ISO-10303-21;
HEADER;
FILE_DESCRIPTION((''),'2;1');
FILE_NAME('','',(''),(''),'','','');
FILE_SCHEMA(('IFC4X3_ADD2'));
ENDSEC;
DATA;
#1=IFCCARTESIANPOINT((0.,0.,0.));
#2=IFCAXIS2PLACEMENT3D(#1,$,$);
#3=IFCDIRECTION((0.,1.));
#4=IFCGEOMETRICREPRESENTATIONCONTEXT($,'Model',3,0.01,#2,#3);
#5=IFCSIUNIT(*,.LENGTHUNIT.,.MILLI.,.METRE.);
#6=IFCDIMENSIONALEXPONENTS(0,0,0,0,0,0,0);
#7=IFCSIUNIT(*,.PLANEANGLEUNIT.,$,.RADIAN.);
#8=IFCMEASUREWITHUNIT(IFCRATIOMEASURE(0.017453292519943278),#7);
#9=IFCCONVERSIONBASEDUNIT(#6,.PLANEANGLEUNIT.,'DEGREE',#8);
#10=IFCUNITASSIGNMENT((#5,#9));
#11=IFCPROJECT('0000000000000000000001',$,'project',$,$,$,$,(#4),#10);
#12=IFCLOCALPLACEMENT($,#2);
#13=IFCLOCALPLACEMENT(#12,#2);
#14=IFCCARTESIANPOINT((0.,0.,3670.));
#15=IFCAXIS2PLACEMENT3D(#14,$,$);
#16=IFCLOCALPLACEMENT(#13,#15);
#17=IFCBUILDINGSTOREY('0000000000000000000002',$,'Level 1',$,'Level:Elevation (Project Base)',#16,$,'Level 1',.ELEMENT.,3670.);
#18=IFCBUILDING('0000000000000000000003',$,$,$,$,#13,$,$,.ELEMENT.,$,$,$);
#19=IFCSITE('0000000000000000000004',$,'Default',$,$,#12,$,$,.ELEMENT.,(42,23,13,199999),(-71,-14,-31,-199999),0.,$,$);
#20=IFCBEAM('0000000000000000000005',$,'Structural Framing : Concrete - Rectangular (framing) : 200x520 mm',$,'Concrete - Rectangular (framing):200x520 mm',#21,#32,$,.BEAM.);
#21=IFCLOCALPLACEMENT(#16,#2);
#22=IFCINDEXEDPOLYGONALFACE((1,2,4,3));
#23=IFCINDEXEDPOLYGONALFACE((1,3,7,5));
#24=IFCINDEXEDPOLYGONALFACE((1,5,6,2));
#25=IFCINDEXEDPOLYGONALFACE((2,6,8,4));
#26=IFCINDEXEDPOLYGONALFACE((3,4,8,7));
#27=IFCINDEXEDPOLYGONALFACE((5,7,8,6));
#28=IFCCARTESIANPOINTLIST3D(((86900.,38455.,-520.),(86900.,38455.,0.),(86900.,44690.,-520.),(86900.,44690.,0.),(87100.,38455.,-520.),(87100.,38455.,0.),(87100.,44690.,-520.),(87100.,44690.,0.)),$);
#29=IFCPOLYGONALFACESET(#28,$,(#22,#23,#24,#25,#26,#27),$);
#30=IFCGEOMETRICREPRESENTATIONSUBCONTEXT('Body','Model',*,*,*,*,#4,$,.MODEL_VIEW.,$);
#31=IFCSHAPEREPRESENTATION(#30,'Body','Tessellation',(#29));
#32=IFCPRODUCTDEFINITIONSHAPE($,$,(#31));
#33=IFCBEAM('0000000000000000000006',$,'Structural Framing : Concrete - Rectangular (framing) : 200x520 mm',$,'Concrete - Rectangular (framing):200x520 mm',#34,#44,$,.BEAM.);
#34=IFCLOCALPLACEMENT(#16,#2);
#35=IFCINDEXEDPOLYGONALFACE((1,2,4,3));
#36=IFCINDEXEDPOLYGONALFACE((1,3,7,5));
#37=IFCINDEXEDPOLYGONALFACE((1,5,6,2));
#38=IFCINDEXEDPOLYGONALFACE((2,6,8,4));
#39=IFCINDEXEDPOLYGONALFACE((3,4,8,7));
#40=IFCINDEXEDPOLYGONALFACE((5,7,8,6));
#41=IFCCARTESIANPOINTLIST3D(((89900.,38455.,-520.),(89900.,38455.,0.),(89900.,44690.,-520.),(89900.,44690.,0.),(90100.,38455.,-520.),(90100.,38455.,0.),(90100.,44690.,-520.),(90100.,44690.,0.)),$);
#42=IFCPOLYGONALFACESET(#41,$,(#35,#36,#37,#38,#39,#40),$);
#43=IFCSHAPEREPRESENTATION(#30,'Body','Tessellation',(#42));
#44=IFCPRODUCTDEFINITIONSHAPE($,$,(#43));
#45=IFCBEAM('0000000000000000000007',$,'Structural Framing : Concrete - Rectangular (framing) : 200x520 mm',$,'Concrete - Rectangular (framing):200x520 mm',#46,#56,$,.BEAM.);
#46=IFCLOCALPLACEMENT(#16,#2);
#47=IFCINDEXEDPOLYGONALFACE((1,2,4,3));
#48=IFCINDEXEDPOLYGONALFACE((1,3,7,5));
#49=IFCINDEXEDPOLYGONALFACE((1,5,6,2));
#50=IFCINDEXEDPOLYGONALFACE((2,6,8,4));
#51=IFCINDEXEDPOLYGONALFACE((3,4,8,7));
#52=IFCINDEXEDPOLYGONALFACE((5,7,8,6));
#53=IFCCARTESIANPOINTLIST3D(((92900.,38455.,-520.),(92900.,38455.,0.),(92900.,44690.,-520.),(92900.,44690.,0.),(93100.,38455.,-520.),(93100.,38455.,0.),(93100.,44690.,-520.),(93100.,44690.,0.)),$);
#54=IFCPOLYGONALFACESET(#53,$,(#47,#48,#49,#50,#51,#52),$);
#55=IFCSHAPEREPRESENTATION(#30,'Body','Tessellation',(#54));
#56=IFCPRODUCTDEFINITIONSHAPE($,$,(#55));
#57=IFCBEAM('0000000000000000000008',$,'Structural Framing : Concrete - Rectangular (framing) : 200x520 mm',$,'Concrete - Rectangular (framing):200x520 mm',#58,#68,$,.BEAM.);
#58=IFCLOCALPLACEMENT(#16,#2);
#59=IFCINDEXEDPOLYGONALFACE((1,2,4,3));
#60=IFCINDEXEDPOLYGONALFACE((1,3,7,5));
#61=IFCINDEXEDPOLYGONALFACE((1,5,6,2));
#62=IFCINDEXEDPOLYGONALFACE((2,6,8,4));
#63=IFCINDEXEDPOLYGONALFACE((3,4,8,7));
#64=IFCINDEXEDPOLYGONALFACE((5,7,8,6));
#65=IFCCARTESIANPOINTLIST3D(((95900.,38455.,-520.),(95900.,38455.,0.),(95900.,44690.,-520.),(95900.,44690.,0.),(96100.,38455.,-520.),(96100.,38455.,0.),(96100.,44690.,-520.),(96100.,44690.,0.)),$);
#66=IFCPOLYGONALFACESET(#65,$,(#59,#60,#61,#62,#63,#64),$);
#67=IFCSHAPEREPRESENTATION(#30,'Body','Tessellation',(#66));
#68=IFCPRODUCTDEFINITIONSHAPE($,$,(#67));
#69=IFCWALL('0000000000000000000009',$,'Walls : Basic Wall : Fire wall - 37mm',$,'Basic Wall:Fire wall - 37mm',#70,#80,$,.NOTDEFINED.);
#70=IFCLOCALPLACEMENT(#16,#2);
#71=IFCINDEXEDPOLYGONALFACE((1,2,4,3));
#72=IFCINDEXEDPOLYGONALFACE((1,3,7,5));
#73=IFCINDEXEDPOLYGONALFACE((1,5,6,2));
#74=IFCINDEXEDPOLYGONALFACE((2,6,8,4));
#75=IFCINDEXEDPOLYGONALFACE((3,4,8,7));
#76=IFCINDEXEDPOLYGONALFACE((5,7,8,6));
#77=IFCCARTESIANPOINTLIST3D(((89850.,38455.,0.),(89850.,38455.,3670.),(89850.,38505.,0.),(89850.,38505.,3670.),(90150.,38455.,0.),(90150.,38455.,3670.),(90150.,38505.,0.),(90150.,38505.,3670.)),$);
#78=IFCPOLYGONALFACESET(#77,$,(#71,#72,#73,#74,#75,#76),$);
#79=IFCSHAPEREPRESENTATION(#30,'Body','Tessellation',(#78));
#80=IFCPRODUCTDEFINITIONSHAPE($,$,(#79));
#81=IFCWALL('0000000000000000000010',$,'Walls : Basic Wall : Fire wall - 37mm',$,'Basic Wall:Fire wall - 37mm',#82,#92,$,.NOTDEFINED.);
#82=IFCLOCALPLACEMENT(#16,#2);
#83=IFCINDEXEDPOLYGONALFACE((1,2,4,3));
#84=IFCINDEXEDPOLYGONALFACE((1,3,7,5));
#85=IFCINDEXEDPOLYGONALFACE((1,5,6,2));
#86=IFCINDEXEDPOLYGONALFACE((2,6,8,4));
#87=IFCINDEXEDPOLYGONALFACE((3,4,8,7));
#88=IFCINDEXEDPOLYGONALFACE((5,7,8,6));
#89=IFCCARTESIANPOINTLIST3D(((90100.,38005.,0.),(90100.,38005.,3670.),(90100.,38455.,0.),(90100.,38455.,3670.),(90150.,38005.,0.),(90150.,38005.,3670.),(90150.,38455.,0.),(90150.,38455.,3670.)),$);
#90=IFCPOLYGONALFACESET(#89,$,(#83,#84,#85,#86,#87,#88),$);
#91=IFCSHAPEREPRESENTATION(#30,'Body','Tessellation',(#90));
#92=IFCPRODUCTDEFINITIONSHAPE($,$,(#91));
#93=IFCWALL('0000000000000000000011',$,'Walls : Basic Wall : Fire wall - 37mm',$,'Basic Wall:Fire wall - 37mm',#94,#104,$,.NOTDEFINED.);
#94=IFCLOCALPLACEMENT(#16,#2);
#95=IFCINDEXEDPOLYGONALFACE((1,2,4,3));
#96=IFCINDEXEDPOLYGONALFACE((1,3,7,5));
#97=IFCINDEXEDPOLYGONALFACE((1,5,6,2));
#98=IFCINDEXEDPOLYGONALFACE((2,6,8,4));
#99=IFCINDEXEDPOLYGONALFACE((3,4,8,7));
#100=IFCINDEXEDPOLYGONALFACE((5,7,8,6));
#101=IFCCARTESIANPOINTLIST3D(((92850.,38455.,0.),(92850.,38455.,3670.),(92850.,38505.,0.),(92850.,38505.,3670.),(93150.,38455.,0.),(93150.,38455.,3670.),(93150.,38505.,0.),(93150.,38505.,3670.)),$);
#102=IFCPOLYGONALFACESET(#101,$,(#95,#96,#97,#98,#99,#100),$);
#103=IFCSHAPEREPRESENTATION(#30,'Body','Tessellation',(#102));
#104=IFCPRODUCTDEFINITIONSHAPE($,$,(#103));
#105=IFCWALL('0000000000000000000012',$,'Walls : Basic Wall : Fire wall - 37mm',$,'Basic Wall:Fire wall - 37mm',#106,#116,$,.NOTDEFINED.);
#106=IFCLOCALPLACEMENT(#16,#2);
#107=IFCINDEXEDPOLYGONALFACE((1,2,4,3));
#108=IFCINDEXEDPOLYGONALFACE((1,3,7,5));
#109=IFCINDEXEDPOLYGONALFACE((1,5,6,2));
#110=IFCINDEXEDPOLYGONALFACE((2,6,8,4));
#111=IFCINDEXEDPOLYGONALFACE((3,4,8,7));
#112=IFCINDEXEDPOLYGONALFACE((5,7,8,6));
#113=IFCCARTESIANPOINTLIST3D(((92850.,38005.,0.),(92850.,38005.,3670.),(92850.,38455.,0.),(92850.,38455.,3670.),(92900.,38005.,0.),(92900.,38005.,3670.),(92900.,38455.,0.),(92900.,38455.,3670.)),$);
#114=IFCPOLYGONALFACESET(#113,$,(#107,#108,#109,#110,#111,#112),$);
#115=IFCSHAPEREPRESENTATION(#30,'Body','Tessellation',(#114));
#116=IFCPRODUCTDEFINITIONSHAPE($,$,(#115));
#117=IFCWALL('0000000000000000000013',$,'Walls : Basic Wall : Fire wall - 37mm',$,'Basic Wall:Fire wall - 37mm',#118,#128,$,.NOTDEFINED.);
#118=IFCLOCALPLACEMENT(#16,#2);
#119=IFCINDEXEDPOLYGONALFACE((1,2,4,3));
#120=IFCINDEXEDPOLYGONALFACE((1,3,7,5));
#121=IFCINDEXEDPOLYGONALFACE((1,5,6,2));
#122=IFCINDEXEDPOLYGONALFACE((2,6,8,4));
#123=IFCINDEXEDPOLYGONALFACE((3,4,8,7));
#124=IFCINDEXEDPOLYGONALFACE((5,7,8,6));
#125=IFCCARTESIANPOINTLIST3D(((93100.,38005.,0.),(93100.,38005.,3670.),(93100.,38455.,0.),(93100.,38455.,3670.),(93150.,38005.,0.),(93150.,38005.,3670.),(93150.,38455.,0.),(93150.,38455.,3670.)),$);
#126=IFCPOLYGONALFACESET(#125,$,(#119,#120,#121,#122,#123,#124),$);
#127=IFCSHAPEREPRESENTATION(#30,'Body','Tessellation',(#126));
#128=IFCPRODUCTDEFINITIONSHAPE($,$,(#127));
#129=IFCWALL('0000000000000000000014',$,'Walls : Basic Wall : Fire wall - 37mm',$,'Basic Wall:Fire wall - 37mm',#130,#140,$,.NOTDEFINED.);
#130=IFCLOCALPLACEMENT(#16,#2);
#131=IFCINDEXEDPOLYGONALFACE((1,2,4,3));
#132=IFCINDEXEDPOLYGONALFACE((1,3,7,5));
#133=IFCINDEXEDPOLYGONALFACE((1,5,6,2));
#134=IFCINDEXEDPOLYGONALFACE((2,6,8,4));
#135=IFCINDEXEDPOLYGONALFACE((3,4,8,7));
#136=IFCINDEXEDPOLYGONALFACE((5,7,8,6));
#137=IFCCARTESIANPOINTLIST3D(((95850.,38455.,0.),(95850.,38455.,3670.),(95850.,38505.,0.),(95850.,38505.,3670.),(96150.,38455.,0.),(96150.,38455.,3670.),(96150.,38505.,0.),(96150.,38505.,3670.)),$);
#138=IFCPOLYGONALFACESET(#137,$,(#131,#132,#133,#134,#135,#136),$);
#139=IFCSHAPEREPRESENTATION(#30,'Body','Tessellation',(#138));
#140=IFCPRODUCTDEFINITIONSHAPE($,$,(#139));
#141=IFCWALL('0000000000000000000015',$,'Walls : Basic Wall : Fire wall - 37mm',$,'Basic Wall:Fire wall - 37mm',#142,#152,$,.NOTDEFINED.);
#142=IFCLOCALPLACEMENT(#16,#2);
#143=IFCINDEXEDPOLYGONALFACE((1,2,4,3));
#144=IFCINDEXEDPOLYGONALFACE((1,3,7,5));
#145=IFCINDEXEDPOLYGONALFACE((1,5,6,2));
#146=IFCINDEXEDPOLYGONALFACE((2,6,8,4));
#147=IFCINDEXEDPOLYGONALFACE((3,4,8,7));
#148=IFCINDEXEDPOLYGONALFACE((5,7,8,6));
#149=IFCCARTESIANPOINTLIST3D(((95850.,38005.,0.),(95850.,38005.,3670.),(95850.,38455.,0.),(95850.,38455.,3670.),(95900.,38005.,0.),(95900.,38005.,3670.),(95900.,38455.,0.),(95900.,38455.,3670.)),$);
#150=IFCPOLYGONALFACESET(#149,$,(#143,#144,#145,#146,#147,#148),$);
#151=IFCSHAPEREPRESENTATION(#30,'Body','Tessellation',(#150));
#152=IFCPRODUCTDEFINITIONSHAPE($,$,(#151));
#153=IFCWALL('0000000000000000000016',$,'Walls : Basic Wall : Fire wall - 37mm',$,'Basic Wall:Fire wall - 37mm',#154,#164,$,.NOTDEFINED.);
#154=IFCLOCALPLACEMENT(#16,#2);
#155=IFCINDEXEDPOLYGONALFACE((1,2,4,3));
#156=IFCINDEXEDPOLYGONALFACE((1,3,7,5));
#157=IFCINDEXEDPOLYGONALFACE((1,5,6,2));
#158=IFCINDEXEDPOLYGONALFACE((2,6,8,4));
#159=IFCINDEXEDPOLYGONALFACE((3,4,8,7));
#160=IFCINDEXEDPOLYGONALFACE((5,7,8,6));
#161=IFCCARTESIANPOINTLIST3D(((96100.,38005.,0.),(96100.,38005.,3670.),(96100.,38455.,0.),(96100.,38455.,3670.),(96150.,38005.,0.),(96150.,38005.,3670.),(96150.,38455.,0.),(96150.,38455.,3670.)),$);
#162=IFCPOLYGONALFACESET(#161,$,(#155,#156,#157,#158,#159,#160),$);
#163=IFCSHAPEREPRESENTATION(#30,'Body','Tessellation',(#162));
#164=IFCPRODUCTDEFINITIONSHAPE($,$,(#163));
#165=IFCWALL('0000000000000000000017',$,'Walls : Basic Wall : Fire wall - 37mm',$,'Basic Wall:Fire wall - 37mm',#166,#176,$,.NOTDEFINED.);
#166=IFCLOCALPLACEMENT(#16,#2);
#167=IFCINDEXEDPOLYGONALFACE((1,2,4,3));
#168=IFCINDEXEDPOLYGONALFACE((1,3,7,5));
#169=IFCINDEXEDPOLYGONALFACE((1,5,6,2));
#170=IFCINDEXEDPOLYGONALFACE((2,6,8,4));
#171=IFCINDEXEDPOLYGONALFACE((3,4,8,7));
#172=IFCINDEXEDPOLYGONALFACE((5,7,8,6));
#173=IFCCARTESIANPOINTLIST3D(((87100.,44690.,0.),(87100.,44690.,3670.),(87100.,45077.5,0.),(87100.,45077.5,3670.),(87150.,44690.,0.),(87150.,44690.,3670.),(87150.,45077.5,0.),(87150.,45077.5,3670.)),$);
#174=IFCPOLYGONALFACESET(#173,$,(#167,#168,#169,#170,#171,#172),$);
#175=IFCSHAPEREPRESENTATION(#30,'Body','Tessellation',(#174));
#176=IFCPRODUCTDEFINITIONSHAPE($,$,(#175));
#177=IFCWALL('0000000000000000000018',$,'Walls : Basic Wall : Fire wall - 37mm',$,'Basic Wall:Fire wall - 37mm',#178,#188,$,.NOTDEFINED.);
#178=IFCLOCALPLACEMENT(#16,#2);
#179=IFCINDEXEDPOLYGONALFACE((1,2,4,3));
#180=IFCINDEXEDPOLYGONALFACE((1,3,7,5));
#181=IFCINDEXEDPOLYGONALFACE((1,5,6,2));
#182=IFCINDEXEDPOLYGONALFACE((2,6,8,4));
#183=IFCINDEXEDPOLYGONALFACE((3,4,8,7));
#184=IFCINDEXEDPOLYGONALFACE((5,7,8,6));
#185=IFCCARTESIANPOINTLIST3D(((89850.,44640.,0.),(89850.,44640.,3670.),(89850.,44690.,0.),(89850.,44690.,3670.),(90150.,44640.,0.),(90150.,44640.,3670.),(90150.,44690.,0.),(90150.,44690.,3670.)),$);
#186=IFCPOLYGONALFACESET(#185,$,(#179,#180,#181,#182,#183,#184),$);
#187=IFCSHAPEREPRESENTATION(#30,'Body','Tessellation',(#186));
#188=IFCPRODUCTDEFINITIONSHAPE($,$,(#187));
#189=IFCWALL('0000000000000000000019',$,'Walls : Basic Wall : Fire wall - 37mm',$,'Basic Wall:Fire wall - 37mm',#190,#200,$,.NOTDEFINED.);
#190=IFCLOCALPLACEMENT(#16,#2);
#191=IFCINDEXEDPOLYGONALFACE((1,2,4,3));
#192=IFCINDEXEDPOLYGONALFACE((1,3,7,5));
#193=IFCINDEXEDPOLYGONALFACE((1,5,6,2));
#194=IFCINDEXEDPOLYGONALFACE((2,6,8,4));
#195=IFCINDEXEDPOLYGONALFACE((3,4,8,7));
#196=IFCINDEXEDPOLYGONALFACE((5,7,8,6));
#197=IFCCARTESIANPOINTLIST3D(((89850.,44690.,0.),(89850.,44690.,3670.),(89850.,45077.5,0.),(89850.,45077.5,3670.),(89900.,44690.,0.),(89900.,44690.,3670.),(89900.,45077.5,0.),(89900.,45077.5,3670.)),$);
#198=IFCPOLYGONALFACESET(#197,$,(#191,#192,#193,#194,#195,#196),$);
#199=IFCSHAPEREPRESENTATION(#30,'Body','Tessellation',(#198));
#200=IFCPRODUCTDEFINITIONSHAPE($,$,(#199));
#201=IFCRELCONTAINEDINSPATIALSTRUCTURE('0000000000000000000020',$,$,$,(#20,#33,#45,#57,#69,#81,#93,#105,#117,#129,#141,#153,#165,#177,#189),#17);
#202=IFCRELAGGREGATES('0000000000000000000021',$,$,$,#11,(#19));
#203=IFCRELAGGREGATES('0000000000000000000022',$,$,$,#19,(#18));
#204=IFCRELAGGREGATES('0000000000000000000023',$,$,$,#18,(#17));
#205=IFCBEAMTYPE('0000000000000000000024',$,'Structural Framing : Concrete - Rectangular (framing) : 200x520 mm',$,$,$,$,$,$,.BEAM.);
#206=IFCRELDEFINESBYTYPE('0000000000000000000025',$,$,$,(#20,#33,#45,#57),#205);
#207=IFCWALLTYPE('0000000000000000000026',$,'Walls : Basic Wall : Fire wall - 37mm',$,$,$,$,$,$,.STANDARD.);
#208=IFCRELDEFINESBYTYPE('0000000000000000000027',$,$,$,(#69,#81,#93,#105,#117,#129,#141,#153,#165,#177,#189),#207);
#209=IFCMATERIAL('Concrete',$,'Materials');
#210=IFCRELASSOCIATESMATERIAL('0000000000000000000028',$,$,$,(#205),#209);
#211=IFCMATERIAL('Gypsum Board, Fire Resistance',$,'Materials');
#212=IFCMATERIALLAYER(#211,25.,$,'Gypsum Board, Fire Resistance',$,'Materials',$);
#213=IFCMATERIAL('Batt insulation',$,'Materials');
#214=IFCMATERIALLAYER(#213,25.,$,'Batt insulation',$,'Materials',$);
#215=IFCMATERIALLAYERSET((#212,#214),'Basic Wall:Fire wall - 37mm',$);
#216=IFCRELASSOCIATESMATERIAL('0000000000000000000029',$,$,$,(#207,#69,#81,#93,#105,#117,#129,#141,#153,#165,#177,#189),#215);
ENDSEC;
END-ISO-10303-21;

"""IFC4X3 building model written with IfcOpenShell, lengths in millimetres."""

from ifc_helpers import new_model, entity, si_unit, converted_unit, direction, frame, frame_2d, origin, place, context, subcontext, project, spatial, rectangle, extrude, source, transform, mapped, material, layer, layer_set, material_profile, profile_set, type_object, type_shapes, element, save


model = new_model("IFC4X3")

# Units and contexts
model_context = context("Model", 3, precision=0.01, world=origin(), true_north=direction((0.0, 1.0)))
body_context = subcontext(model_context, "Body", "Model", "MODEL_VIEW")
ifc_project = project(units=[si_unit("LENGTHUNIT", "METRE", prefix="MILLI"), converted_unit("PLANEANGLEUNIT", "DEGREE", entity("IfcRatioMeasure", 0.017453292519943278), si_unit("PLANEANGLEUNIT", "RADIAN"), dimensions=[0, 0, 0, 0, 0, 0, 0])], contexts=[model_context])

# Site, building, storey
site_placement = place(None, origin())
site = spatial("IfcSite", under=ifc_project, at=site_placement, Name="Default", CompositionType="ELEMENT", RefLatitude=(42, 23, 13, 199999), RefLongitude=(-71, -14, -31, -199999), RefElevation=0.0)
building_placement = place(site_placement, origin())
building = spatial("IfcBuilding", under=site, at=building_placement, CompositionType="ELEMENT")
storey_placement = place(building_placement, frame((0.0, 0.0, 3670.0)))
storey = spatial("IfcBuildingStorey", under=building, at=storey_placement, Name="Level 1", ObjectType="Level:Elevation (Project Base)", LongName="Level 1", CompositionType="ELEMENT", Elevation=3670.0)

# Beams
ifc_material_1 = material(Name="Concrete", Category="Materials")
ifc_material_profile = material_profile(ifc_material_1, rectangle(XDim=520.0, YDim=200.0, at=frame_2d((0.0, 0.0), x_axis=(1.0, 0.0))), Name="200x520 mm")
ifc_profile_set = profile_set([ifc_material_profile], Name="200x520 mm")
beam_type = type_object("IfcBeamType", Name="Structural Framing : Concrete - Rectangular (framing) : 200x520 mm", PredefinedType="BEAM", material=ifc_profile_set)
shared_shape = source(origin(), body_context, "Body", "SweptSolid", [
    extrude(rectangle(XDim=520.0, YDim=200.0, at=frame_2d((0.0, 0.0), x_axis=(1.0, 0.0))), frame((-1350.0, 0.0, 0.0), z_axis=(1.0, 0.0, 0.0), x_axis=(0.0, 0.0, -1.0)), (0.0, 0.0, 1.0), 6235.0),
])
type_shapes(beam_type, [shared_shape])
for number, where, z_axis, x_axis, name in (
    (1, (87000.0, 43340.0, -260.0), (0.0, 0.0, 1.0), (0.0, -1.0, 0.0), "Structural Framing : Concrete - Rectangular (framing) : 200x520 mm"),
    (2, (90000.0, 43340.0, -260.0), (0.0, 0.0, 1.0), (0.0, -1.0, 0.0), "Structural Framing : Concrete - Rectangular (framing) : 200x520 mm"),
    (3, (93000.0, 43340.0, -260.0), (0.0, 0.0, 1.0), (0.0, -1.0, 0.0), "Structural Framing : Concrete - Rectangular (framing) : 200x520 mm"),
    (4, (96000.0, 43340.0, -260.0), (0.0, 0.0, 1.0), (0.0, -1.0, 0.0), "Structural Framing : Concrete - Rectangular (framing) : 200x520 mm"),
):
    element("IfcBeam", number, at=place(storey_placement, frame(where, z_axis=z_axis, x_axis=x_axis)), inside=storey, type_object=beam_type, Name=name, ObjectType="Concrete - Rectangular (framing):200x520 mm", PredefinedType="BEAM", context=body_context, shape_type="MappedRepresentation", body=[
        mapped(shared_shape, transform((0.0, 0.0, 0.0), scale=1.0)),
    ])

# Walls
ifc_material_2 = material(Name="Gypsum Board, Fire Resistance", Category="Materials")
ifc_layer_1 = layer(ifc_material_2, 25.0, Name="Gypsum Board, Fire Resistance", Category="Materials")
ifc_material_3 = material(Name="Batt insulation", Category="Materials")
ifc_layer_2 = layer(ifc_material_3, 25.0, Name="Batt insulation", Category="Materials")
ifc_layer_set = layer_set([ifc_layer_1, ifc_layer_2], Name="Basic Wall:Fire wall - 37mm")
wall_type = type_object("IfcWallType", Name="Walls : Basic Wall : Fire wall - 37mm", PredefinedType="STANDARD", material=ifc_layer_set)
wall_1_placement = place(storey_placement, frame((89850.0, 38480.0, 0.0)))
element("IfcWall", 5, at=wall_1_placement, inside=storey, type_object=wall_type, material=ifc_layer_set, Name="Walls : Basic Wall : Fire wall - 37mm", ObjectType="Basic Wall:Fire wall - 37mm", PredefinedType="NOTDEFINED", context=body_context, shape_type="SweptSolid", body=[
    extrude(rectangle(XDim=300.0, YDim=50.0, at=frame_2d((150.0, 0.0), x_axis=(-1.0, 0.0))), origin(), (0.0, 0.0, 1.0), 3670.0),
])
wall_2_placement = place(storey_placement, frame((90125.0, 38455.0, 0.0), z_axis=(0.0, 0.0, 1.0), x_axis=(0.0, -1.0, 0.0)))
element("IfcWall", 6, at=wall_2_placement, inside=storey, type_object=wall_type, material=ifc_layer_set, Name="Walls : Basic Wall : Fire wall - 37mm", ObjectType="Basic Wall:Fire wall - 37mm", PredefinedType="NOTDEFINED", context=body_context, shape_type="SweptSolid", body=[
    extrude(rectangle(XDim=450.0, YDim=50.0, at=frame_2d((225.0, 0.0), x_axis=(-1.0, 0.0))), origin(), (0.0, 0.0, 1.0), 3670.0),
])
wall_3_placement = place(storey_placement, frame((92850.0, 38480.0, 0.0)))
element("IfcWall", 7, at=wall_3_placement, inside=storey, type_object=wall_type, material=ifc_layer_set, Name="Walls : Basic Wall : Fire wall - 37mm", ObjectType="Basic Wall:Fire wall - 37mm", PredefinedType="NOTDEFINED", context=body_context, shape_type="SweptSolid", body=[
    extrude(rectangle(XDim=300.0, YDim=50.0, at=frame_2d((150.0, 0.0), x_axis=(-1.0, 0.0))), origin(), (0.0, 0.0, 1.0), 3670.0),
])
for number, where, z_axis, x_axis, name in (
    (8, (92875.0, 38455.0, 0.0), (0.0, 0.0, 1.0), (0.0, -1.0, 0.0), "Walls : Basic Wall : Fire wall - 37mm"),
    (9, (93125.0, 38455.0, 0.0), (0.0, 0.0, 1.0), (0.0, -1.0, 0.0), "Walls : Basic Wall : Fire wall - 37mm"),
):
    element("IfcWall", number, at=place(storey_placement, frame(where, z_axis=z_axis, x_axis=x_axis)), inside=storey, type_object=wall_type, material=ifc_layer_set, Name=name, ObjectType="Basic Wall:Fire wall - 37mm", PredefinedType="NOTDEFINED", context=body_context, shape_type="SweptSolid", body=[
        extrude(rectangle(XDim=450.0, YDim=50.0, at=frame_2d((225.0, 0.0), x_axis=(-1.0, 0.0))), origin(), (0.0, 0.0, 1.0), 3670.0),
    ])
wall_4_placement = place(storey_placement, frame((95850.0, 38480.0, 0.0)))
element("IfcWall", 10, at=wall_4_placement, inside=storey, type_object=wall_type, material=ifc_layer_set, Name="Walls : Basic Wall : Fire wall - 37mm", ObjectType="Basic Wall:Fire wall - 37mm", PredefinedType="NOTDEFINED", context=body_context, shape_type="SweptSolid", body=[
    extrude(rectangle(XDim=300.0, YDim=50.0, at=frame_2d((150.0, 0.0), x_axis=(-1.0, 0.0))), origin(), (0.0, 0.0, 1.0), 3670.0),
])
for number, where, z_axis, x_axis, name in (
    (11, (95875.0, 38455.0, 0.0), (0.0, 0.0, 1.0), (0.0, -1.0, 0.0), "Walls : Basic Wall : Fire wall - 37mm"),
    (12, (96125.0, 38455.0, 0.0), (0.0, 0.0, 1.0), (0.0, -1.0, 0.0), "Walls : Basic Wall : Fire wall - 37mm"),
):
    element("IfcWall", number, at=place(storey_placement, frame(where, z_axis=z_axis, x_axis=x_axis)), inside=storey, type_object=wall_type, material=ifc_layer_set, Name=name, ObjectType="Basic Wall:Fire wall - 37mm", PredefinedType="NOTDEFINED", context=body_context, shape_type="SweptSolid", body=[
        extrude(rectangle(XDim=450.0, YDim=50.0, at=frame_2d((225.0, 0.0), x_axis=(-1.0, 0.0))), origin(), (0.0, 0.0, 1.0), 3670.0),
    ])
wall_5_placement = place(storey_placement, frame((87125.0, 45077.5, 0.0), z_axis=(0.0, 0.0, 1.0), x_axis=(0.0, -1.0, 0.0)))
element("IfcWall", 13, at=wall_5_placement, inside=storey, type_object=wall_type, material=ifc_layer_set, Name="Walls : Basic Wall : Fire wall - 37mm", ObjectType="Basic Wall:Fire wall - 37mm", PredefinedType="NOTDEFINED", context=body_context, shape_type="SweptSolid", body=[
    extrude(rectangle(XDim=387.5, YDim=50.0, at=frame_2d((193.7, 0.0), x_axis=(-1.0, 0.0))), origin(), (0.0, 0.0, 1.0), 3670.0),
])
wall_6_placement = place(storey_placement, frame((89850.0, 44665.0, 0.0)))
element("IfcWall", 14, at=wall_6_placement, inside=storey, type_object=wall_type, material=ifc_layer_set, Name="Walls : Basic Wall : Fire wall - 37mm", ObjectType="Basic Wall:Fire wall - 37mm", PredefinedType="NOTDEFINED", context=body_context, shape_type="SweptSolid", body=[
    extrude(rectangle(XDim=300.0, YDim=50.0, at=frame_2d((150.0, 0.0), x_axis=(-1.0, 0.0))), origin(), (0.0, 0.0, 1.0), 3670.0),
])
for number, where, z_axis, x_axis, name in (
    (15, (89875.0, 45077.5, 0.0), (0.0, 0.0, 1.0), (0.0, -1.0, 0.0), "Walls : Basic Wall : Fire wall - 37mm"),
):
    element("IfcWall", number, at=place(storey_placement, frame(where, z_axis=z_axis, x_axis=x_axis)), inside=storey, type_object=wall_type, material=ifc_layer_set, Name=name, ObjectType="Basic Wall:Fire wall - 37mm", PredefinedType="NOTDEFINED", context=body_context, shape_type="SweptSolid", body=[
        extrude(rectangle(XDim=387.5, YDim=50.0, at=frame_2d((193.7, 0.0), x_axis=(-1.0, 0.0))), origin(), (0.0, 0.0, 1.0), 3670.0),
    ])

save(model, "model.ifc")
